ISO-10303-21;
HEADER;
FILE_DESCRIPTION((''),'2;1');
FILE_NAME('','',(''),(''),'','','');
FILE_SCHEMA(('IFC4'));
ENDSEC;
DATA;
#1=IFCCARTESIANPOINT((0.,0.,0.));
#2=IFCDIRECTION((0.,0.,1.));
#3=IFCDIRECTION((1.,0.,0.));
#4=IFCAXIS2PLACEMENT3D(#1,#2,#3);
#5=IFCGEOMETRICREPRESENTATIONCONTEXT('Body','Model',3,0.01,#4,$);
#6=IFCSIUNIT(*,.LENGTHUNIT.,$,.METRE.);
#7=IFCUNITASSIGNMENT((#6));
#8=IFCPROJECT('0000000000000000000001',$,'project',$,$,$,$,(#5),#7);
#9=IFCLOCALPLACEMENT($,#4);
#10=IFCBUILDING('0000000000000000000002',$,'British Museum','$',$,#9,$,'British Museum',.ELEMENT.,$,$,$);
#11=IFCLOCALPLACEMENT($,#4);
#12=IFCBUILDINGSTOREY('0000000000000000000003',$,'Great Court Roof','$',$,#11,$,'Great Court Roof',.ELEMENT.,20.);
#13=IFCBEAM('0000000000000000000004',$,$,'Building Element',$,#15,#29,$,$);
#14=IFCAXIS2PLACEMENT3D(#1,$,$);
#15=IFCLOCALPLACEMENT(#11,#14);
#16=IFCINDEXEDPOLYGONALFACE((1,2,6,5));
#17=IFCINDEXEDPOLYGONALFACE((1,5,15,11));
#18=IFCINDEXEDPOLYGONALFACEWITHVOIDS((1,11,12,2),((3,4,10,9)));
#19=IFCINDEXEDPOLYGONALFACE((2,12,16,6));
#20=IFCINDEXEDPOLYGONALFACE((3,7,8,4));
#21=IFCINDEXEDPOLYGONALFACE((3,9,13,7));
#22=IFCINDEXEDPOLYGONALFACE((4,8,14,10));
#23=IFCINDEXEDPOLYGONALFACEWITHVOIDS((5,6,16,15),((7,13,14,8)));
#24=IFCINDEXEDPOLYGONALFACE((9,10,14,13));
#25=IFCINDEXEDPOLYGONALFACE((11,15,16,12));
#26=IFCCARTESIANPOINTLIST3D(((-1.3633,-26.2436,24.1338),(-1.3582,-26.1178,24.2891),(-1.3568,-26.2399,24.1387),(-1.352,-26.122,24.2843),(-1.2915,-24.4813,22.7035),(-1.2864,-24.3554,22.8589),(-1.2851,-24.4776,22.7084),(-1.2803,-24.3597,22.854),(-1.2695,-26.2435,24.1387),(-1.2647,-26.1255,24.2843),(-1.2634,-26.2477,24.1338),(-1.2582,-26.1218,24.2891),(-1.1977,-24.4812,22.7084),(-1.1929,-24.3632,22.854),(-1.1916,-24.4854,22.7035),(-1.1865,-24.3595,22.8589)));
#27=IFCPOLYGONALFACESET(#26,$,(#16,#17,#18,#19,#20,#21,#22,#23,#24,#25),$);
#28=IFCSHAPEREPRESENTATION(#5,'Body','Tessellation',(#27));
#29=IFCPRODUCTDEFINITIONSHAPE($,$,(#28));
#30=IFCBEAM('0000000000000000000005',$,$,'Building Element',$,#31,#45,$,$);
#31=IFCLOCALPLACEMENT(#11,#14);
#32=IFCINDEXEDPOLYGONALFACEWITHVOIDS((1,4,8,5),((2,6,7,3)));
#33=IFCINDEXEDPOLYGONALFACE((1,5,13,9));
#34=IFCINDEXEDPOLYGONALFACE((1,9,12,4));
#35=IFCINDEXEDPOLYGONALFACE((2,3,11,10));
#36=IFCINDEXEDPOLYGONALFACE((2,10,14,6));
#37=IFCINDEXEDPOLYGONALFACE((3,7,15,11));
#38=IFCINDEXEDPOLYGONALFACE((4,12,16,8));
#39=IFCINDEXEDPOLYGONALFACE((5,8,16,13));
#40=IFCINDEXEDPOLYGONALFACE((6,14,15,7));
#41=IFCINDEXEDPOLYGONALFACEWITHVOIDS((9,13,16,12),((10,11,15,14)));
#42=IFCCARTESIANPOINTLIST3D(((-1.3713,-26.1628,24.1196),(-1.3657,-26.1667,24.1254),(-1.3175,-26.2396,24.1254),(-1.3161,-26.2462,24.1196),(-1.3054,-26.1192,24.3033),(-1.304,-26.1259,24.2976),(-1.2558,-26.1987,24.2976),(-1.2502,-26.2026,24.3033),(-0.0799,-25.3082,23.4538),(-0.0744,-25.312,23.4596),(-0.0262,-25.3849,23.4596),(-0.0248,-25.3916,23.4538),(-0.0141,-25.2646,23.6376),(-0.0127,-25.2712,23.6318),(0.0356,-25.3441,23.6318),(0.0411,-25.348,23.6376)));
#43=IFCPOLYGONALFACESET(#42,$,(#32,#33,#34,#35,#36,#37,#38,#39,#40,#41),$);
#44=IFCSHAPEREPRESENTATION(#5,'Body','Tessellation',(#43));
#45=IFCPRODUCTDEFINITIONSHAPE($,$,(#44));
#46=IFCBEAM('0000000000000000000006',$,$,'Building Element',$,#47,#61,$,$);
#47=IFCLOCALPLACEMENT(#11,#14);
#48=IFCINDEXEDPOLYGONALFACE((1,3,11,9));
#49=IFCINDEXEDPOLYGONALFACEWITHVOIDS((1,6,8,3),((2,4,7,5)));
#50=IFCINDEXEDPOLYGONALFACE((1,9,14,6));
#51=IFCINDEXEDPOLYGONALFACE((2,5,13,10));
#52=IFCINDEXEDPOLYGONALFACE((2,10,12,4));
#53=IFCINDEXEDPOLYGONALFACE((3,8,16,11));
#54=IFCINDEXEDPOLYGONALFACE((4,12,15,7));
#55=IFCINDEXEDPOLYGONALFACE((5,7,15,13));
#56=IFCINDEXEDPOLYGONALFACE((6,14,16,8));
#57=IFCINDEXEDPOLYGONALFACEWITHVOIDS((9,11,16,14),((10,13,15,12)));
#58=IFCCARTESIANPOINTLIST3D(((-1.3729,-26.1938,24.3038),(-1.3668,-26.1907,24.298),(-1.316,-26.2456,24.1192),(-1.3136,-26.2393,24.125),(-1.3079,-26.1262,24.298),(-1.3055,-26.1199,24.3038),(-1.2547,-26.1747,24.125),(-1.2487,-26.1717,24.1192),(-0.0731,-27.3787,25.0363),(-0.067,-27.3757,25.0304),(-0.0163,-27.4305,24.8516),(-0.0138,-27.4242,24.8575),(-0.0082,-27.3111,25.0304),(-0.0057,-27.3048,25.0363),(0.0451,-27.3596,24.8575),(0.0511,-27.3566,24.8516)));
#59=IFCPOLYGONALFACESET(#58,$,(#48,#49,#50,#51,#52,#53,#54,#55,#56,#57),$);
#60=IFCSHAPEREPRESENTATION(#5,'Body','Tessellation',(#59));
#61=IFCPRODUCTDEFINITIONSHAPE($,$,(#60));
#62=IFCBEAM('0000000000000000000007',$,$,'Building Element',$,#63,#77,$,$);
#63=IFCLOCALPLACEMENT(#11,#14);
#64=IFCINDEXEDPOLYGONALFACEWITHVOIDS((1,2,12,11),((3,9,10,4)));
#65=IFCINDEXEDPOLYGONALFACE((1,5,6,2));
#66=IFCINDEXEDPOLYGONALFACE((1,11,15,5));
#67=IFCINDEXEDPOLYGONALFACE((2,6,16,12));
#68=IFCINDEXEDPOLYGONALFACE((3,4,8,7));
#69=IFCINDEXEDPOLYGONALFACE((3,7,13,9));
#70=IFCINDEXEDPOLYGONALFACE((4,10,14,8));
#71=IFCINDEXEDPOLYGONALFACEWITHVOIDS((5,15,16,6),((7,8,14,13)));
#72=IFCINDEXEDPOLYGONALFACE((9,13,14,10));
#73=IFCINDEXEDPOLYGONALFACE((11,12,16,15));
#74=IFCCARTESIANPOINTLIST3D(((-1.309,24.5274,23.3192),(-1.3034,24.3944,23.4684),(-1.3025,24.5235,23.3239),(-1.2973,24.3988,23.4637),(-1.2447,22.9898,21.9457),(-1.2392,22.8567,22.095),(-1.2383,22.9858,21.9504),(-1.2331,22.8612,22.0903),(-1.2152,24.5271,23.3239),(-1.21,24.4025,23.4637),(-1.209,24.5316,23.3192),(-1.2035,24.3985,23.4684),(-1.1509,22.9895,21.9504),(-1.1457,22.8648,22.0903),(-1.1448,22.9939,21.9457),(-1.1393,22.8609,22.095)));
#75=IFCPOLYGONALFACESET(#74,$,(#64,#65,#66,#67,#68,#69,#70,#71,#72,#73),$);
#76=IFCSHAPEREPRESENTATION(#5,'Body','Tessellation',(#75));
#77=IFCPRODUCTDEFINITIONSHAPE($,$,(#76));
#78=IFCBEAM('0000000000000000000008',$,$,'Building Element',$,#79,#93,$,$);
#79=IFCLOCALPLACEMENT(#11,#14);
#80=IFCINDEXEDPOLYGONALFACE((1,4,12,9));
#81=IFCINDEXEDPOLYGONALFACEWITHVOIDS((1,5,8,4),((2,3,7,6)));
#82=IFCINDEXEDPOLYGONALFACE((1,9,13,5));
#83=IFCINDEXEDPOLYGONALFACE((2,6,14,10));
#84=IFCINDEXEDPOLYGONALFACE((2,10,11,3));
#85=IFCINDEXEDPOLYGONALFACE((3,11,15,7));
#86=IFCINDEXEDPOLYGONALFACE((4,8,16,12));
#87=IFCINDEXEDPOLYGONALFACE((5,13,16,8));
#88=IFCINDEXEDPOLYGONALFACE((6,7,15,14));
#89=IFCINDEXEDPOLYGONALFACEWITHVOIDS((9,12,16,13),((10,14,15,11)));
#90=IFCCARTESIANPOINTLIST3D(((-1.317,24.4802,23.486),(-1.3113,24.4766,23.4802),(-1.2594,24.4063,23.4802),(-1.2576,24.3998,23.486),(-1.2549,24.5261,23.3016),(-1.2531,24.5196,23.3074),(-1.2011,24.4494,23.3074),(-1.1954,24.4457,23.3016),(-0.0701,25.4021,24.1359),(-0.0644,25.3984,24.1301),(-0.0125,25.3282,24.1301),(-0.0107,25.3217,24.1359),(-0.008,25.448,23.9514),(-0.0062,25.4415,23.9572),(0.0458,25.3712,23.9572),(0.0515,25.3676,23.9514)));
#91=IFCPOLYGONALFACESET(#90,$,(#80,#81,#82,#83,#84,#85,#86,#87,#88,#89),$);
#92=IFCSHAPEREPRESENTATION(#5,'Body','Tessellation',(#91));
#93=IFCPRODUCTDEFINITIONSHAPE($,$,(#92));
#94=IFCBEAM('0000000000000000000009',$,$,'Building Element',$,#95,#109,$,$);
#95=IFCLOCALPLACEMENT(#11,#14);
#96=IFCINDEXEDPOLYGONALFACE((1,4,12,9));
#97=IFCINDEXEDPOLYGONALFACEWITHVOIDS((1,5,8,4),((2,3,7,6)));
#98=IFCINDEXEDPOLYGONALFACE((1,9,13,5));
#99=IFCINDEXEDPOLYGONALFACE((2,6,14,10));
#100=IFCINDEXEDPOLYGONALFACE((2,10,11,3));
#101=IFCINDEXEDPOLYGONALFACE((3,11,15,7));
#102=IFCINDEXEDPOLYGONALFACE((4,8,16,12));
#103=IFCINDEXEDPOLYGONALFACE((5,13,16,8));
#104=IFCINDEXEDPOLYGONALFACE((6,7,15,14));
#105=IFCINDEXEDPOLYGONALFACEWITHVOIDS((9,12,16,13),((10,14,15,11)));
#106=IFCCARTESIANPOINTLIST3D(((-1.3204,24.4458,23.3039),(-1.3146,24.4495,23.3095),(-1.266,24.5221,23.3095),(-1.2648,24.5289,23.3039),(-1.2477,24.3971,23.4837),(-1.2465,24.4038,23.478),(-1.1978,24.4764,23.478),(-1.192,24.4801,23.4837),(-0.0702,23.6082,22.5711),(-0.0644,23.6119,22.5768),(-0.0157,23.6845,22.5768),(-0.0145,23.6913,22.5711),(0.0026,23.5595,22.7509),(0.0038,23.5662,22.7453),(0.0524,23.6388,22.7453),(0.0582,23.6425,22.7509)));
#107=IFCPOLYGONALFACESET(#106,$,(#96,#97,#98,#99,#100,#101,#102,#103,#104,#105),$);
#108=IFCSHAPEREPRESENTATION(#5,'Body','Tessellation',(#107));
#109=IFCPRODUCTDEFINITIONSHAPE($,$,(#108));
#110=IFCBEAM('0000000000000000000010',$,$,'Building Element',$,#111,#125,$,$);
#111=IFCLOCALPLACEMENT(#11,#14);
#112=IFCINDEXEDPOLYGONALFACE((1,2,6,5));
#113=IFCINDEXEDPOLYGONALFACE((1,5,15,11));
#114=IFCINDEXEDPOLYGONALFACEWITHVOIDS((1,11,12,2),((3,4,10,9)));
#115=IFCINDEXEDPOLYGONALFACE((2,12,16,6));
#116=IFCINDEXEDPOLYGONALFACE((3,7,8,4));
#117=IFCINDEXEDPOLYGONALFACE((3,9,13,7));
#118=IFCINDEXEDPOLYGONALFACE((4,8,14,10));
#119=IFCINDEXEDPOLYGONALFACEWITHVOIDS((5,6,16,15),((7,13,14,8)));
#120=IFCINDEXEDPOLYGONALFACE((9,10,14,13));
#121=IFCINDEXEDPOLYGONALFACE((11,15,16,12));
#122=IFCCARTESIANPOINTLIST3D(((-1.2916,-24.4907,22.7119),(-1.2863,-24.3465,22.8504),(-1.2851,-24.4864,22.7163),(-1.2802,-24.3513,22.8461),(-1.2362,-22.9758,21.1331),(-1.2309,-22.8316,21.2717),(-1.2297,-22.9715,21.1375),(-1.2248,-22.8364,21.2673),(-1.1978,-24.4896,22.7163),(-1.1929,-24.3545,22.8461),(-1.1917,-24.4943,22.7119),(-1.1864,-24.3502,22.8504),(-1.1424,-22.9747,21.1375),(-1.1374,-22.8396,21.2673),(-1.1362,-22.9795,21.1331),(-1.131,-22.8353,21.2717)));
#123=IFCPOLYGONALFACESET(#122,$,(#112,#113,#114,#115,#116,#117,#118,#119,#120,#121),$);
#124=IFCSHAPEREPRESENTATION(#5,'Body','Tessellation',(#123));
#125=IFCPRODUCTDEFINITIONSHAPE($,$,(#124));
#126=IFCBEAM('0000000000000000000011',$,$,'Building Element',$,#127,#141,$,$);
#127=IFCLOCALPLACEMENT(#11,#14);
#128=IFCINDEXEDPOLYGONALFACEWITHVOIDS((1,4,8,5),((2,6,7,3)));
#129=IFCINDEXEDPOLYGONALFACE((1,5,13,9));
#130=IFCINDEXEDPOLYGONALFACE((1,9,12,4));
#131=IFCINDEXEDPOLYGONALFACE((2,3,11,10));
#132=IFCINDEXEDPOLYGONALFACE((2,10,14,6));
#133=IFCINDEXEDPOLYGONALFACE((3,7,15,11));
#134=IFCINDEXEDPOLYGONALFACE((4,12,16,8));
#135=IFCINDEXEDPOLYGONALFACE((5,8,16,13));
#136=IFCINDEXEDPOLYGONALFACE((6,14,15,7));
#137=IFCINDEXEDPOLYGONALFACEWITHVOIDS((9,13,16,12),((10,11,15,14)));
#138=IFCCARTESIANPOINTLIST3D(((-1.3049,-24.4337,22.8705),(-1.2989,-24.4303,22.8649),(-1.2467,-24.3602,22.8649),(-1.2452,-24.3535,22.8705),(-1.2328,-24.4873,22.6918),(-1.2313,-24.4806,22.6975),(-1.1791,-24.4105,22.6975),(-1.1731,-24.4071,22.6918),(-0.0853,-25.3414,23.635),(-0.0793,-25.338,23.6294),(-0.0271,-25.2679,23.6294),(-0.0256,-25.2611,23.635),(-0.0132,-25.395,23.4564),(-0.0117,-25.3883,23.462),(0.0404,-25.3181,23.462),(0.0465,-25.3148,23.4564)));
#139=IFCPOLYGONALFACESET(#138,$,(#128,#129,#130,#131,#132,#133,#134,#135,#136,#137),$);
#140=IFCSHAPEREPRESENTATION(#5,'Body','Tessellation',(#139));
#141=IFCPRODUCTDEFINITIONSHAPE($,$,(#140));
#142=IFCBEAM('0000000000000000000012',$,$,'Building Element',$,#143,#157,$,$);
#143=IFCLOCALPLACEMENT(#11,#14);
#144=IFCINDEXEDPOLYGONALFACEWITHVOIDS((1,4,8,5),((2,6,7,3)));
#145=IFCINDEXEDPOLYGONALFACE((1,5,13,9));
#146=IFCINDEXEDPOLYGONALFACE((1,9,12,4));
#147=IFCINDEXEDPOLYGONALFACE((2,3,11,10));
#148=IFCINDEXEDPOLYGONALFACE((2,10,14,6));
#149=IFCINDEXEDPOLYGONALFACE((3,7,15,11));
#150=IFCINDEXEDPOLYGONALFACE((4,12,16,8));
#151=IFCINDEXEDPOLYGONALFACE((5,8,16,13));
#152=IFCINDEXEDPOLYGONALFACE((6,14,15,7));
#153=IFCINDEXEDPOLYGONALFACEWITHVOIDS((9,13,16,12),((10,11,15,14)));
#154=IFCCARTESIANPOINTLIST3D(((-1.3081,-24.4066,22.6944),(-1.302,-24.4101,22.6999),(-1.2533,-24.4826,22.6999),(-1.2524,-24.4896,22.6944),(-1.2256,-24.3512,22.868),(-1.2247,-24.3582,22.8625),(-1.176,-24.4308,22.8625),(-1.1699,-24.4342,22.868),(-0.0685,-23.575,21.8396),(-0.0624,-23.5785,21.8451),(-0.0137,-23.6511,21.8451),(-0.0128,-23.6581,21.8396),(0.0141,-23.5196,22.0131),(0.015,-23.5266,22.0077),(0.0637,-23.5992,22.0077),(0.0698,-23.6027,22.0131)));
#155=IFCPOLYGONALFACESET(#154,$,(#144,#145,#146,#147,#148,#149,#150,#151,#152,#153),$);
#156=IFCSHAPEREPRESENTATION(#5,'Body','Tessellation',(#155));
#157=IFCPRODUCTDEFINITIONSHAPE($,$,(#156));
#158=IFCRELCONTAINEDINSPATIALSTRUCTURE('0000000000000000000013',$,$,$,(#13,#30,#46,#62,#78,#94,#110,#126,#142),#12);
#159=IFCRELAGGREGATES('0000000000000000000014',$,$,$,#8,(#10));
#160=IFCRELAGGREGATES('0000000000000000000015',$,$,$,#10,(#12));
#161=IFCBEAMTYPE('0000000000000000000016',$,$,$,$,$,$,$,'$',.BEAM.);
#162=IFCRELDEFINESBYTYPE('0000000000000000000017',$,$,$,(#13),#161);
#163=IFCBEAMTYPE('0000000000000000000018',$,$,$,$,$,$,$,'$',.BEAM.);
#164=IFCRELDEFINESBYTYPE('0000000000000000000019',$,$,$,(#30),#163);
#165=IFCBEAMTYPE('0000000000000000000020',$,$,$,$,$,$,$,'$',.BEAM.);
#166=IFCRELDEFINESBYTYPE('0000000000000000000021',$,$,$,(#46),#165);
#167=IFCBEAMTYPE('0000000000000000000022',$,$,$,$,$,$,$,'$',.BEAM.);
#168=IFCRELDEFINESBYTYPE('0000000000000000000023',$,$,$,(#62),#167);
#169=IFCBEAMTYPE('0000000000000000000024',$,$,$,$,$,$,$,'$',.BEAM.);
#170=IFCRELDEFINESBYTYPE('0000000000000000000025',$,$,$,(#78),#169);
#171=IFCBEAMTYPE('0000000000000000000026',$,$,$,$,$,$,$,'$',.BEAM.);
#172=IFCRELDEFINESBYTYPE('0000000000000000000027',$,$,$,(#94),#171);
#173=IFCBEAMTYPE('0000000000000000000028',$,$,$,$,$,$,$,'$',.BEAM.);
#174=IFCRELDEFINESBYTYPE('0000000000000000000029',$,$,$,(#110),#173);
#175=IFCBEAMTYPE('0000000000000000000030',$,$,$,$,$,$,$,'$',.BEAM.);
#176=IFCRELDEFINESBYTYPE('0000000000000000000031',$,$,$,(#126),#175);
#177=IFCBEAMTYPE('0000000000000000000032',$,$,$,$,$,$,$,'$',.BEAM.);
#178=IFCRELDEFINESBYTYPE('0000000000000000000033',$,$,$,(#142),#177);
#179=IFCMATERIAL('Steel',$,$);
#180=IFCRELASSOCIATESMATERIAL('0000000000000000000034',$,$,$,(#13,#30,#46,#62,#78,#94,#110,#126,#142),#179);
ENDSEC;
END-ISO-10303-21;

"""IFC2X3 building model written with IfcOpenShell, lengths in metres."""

from ifc_helpers import new_model, si_unit, frame, origin_with_axes, origin_2d, place, context, project, spatial, hollow_rectangle, extrude, material, type_object, element, save


model = new_model("IFC2X3")

# Units and contexts
model_context = context("Model", 3, precision=0.01, world=origin_with_axes(), identifier="Body")
ifc_project = project(units=[si_unit("LENGTHUNIT", "METRE")], contexts=[model_context])

# Building, storey
building_placement = place(None, origin_with_axes())
building = spatial("IfcBuilding", under=ifc_project, at=building_placement, Name="British Museum", Description="$", LongName="British Museum", CompositionType="ELEMENT")
storey_placement = place(None, origin_with_axes())
storey = spatial("IfcBuildingStorey", under=building, at=storey_placement, Name="Great Court Roof", Description="$", LongName="Great Court Roof", CompositionType="ELEMENT", Elevation=20.0)

# Beams
ifc_material = material(Name="Steel")
beam_type_1 = type_object("IfcBeamType", ElementType="$", PredefinedType="BEAM")
beam_1_placement = place(None, origin_with_axes())
element("IfcBeam", 1, at=beam_1_placement, inside=storey, type_object=beam_type_1, material=ifc_material, Description="Building Element", context=model_context, shape_type="SweptSolid", body=[
    extrude(hollow_rectangle(XDim=0.1, YDim=0.2, WallThickness=0.0063, InnerFilletRadius=-0.0063, OuterFilletRadius=0.0, at=origin_2d()), frame((-1.3108, -26.1827, 24.2115), z_axis=(0.031596, 0.776069, -0.629856), x_axis=(-0.999172, 0.04068, 0.0)), (0.0, 0.0, 1.0), 2.2708),
])
beam_type_2 = type_object("IfcBeamType", ElementType="$", PredefinedType="BEAM")
beam_2_placement = place(None, origin_with_axes())
element("IfcBeam", 2, at=beam_2_placement, inside=storey, type_object=beam_type_2, material=ifc_material, Description="Building Element", context=model_context, shape_type="SweptSolid", body=[
    extrude(hollow_rectangle(XDim=0.1, YDim=0.2, WallThickness=0.0063, InnerFilletRadius=-0.0063, OuterFilletRadius=0.0, at=origin_2d()), frame((-1.3108, -26.1827, 24.2115), z_axis=(0.766098, 0.507033, -0.394982), x_axis=(-0.55191, 0.833904, 0.0)), (0.0, 0.0, 1.0), 1.6856),
])
beam_type_3 = type_object("IfcBeamType", ElementType="$", PredefinedType="BEAM")
beam_3_placement = place(None, origin_with_axes())
element("IfcBeam", 3, at=beam_3_placement, inside=storey, type_object=beam_type_3, material=ifc_material, Description="Building Element", context=model_context, shape_type="SweptSolid", body=[
    extrude(hollow_rectangle(XDim=0.1, YDim=0.2, WallThickness=0.0063, InnerFilletRadius=-0.0063, OuterFilletRadius=0.0, at=origin_2d()), frame((-1.3108, -26.1827, 24.2115), z_axis=(0.682207, -0.621924, 0.384452), x_axis=(0.673702, 0.739003, 0.0)), (0.0, 0.0, 1.0), 1.9052),
])
beam_type_4 = type_object("IfcBeamType", ElementType="$", PredefinedType="BEAM")
beam_4_placement = place(None, origin_with_axes())
element("IfcBeam", 4, at=beam_4_placement, inside=storey, type_object=beam_type_4, material=ifc_material, Description="Building Element", context=model_context, shape_type="SweptSolid", body=[
    extrude(hollow_rectangle(XDim=0.1, YDim=0.2, WallThickness=0.0063, InnerFilletRadius=-0.0063, OuterFilletRadius=0.0, at=origin_2d()), frame((-1.2562, 24.463, 23.3938), z_axis=(0.031135, -0.745444, -0.665841), x_axis=(0.999129, 0.04173, 0.0)), (0.0, 0.0, 1.0), 2.0627),
])
beam_type_5 = type_object("IfcBeamType", ElementType="$", PredefinedType="BEAM")
beam_5_placement = place(None, origin_with_axes())
element("IfcBeam", 5, at=beam_5_placement, inside=storey, type_object=beam_type_5, material=ifc_material, Description="Building Element", context=model_context, shape_type="SweptSolid", body=[
    extrude(hollow_rectangle(XDim=0.1, YDim=0.2, WallThickness=0.0063, InnerFilletRadius=-0.0063, OuterFilletRadius=0.0, at=origin_2d()), frame((-1.2562, 24.463, 23.3938), z_axis=(0.741602, 0.548296, 0.38652), x_axis=(-0.5945, 0.804096, 0.0)), (0.0, 0.0, 1.0), 1.6813),
])
beam_type_6 = type_object("IfcBeamType", ElementType="$", PredefinedType="BEAM")
beam_6_placement = place(None, origin_with_axes())
element("IfcBeam", 6, at=beam_6_placement, inside=storey, type_object=beam_type_6, material=ifc_material, Description="Building Element", context=model_context, shape_type="SweptSolid", body=[
    extrude(hollow_rectangle(XDim=0.1, YDim=0.2, WallThickness=0.0063, InnerFilletRadius=-0.0063, OuterFilletRadius=0.0, at=origin_2d()), frame((-1.2562, 24.463, 23.3938), z_axis=(0.746954, -0.500417, -0.43777), x_axis=(0.556584, 0.830791, 0.0)), (0.0, 0.0, 1.0), 1.6738),
])
beam_type_7 = type_object("IfcBeamType", ElementType="$", PredefinedType="BEAM")
beam_7_placement = place(None, origin_with_axes())
element("IfcBeam", 7, at=beam_7_placement, inside=storey, type_object=beam_type_7, material=ifc_material, Description="Building Element", context=model_context, shape_type="SweptSolid", body=[
    extrude(hollow_rectangle(XDim=0.1, YDim=0.2, WallThickness=0.0063, InnerFilletRadius=-0.0063, OuterFilletRadius=0.0, at=origin_2d()), frame((-1.239, -24.4204, 22.7812), z_axis=(0.025331, 0.692125, -0.721333), x_axis=(-0.999331, 0.036574, 0.0)), (0.0, 0.0, 1.0), 2.1887),
])
beam_type_8 = type_object("IfcBeamType", ElementType="$", PredefinedType="BEAM")
beam_8_placement = place(None, origin_with_axes())
element("IfcBeam", 8, at=beam_8_placement, inside=storey, type_object=beam_type_8, material=ifc_material, Description="Building Element", context=model_context, shape_type="SweptSolid", body=[
    extrude(hollow_rectangle(XDim=0.1, YDim=0.2, WallThickness=0.0063, InnerFilletRadius=-0.0063, OuterFilletRadius=0.0, at=origin_2d()), frame((-1.239, -24.4204, 22.7812), z_axis=(0.716699, -0.533387, 0.449266), x_axis=(0.597032, 0.802217, 0.0)), (0.0, 0.0, 1.0), 1.7017),
])
beam_type_9 = type_object("IfcBeamType", ElementType="$", PredefinedType="BEAM")
beam_9_placement = place(None, origin_with_axes())
element("IfcBeam", 9, at=beam_9_placement, inside=storey, type_object=beam_type_9, material=ifc_material, Description="Building Element", context=model_context, shape_type="SweptSolid", body=[
    extrude(hollow_rectangle(XDim=0.1, YDim=0.2, WallThickness=0.0063, InnerFilletRadius=-0.0063, OuterFilletRadius=0.0, at=origin_2d()), frame((-1.239, -24.4204, 22.7812), z_axis=(0.720663, 0.48342, -0.496941), x_axis=(-0.557074, 0.830463, 0.0)), (0.0, 0.0, 1.0), 1.7202),
])

save(model, "model.ifc")
